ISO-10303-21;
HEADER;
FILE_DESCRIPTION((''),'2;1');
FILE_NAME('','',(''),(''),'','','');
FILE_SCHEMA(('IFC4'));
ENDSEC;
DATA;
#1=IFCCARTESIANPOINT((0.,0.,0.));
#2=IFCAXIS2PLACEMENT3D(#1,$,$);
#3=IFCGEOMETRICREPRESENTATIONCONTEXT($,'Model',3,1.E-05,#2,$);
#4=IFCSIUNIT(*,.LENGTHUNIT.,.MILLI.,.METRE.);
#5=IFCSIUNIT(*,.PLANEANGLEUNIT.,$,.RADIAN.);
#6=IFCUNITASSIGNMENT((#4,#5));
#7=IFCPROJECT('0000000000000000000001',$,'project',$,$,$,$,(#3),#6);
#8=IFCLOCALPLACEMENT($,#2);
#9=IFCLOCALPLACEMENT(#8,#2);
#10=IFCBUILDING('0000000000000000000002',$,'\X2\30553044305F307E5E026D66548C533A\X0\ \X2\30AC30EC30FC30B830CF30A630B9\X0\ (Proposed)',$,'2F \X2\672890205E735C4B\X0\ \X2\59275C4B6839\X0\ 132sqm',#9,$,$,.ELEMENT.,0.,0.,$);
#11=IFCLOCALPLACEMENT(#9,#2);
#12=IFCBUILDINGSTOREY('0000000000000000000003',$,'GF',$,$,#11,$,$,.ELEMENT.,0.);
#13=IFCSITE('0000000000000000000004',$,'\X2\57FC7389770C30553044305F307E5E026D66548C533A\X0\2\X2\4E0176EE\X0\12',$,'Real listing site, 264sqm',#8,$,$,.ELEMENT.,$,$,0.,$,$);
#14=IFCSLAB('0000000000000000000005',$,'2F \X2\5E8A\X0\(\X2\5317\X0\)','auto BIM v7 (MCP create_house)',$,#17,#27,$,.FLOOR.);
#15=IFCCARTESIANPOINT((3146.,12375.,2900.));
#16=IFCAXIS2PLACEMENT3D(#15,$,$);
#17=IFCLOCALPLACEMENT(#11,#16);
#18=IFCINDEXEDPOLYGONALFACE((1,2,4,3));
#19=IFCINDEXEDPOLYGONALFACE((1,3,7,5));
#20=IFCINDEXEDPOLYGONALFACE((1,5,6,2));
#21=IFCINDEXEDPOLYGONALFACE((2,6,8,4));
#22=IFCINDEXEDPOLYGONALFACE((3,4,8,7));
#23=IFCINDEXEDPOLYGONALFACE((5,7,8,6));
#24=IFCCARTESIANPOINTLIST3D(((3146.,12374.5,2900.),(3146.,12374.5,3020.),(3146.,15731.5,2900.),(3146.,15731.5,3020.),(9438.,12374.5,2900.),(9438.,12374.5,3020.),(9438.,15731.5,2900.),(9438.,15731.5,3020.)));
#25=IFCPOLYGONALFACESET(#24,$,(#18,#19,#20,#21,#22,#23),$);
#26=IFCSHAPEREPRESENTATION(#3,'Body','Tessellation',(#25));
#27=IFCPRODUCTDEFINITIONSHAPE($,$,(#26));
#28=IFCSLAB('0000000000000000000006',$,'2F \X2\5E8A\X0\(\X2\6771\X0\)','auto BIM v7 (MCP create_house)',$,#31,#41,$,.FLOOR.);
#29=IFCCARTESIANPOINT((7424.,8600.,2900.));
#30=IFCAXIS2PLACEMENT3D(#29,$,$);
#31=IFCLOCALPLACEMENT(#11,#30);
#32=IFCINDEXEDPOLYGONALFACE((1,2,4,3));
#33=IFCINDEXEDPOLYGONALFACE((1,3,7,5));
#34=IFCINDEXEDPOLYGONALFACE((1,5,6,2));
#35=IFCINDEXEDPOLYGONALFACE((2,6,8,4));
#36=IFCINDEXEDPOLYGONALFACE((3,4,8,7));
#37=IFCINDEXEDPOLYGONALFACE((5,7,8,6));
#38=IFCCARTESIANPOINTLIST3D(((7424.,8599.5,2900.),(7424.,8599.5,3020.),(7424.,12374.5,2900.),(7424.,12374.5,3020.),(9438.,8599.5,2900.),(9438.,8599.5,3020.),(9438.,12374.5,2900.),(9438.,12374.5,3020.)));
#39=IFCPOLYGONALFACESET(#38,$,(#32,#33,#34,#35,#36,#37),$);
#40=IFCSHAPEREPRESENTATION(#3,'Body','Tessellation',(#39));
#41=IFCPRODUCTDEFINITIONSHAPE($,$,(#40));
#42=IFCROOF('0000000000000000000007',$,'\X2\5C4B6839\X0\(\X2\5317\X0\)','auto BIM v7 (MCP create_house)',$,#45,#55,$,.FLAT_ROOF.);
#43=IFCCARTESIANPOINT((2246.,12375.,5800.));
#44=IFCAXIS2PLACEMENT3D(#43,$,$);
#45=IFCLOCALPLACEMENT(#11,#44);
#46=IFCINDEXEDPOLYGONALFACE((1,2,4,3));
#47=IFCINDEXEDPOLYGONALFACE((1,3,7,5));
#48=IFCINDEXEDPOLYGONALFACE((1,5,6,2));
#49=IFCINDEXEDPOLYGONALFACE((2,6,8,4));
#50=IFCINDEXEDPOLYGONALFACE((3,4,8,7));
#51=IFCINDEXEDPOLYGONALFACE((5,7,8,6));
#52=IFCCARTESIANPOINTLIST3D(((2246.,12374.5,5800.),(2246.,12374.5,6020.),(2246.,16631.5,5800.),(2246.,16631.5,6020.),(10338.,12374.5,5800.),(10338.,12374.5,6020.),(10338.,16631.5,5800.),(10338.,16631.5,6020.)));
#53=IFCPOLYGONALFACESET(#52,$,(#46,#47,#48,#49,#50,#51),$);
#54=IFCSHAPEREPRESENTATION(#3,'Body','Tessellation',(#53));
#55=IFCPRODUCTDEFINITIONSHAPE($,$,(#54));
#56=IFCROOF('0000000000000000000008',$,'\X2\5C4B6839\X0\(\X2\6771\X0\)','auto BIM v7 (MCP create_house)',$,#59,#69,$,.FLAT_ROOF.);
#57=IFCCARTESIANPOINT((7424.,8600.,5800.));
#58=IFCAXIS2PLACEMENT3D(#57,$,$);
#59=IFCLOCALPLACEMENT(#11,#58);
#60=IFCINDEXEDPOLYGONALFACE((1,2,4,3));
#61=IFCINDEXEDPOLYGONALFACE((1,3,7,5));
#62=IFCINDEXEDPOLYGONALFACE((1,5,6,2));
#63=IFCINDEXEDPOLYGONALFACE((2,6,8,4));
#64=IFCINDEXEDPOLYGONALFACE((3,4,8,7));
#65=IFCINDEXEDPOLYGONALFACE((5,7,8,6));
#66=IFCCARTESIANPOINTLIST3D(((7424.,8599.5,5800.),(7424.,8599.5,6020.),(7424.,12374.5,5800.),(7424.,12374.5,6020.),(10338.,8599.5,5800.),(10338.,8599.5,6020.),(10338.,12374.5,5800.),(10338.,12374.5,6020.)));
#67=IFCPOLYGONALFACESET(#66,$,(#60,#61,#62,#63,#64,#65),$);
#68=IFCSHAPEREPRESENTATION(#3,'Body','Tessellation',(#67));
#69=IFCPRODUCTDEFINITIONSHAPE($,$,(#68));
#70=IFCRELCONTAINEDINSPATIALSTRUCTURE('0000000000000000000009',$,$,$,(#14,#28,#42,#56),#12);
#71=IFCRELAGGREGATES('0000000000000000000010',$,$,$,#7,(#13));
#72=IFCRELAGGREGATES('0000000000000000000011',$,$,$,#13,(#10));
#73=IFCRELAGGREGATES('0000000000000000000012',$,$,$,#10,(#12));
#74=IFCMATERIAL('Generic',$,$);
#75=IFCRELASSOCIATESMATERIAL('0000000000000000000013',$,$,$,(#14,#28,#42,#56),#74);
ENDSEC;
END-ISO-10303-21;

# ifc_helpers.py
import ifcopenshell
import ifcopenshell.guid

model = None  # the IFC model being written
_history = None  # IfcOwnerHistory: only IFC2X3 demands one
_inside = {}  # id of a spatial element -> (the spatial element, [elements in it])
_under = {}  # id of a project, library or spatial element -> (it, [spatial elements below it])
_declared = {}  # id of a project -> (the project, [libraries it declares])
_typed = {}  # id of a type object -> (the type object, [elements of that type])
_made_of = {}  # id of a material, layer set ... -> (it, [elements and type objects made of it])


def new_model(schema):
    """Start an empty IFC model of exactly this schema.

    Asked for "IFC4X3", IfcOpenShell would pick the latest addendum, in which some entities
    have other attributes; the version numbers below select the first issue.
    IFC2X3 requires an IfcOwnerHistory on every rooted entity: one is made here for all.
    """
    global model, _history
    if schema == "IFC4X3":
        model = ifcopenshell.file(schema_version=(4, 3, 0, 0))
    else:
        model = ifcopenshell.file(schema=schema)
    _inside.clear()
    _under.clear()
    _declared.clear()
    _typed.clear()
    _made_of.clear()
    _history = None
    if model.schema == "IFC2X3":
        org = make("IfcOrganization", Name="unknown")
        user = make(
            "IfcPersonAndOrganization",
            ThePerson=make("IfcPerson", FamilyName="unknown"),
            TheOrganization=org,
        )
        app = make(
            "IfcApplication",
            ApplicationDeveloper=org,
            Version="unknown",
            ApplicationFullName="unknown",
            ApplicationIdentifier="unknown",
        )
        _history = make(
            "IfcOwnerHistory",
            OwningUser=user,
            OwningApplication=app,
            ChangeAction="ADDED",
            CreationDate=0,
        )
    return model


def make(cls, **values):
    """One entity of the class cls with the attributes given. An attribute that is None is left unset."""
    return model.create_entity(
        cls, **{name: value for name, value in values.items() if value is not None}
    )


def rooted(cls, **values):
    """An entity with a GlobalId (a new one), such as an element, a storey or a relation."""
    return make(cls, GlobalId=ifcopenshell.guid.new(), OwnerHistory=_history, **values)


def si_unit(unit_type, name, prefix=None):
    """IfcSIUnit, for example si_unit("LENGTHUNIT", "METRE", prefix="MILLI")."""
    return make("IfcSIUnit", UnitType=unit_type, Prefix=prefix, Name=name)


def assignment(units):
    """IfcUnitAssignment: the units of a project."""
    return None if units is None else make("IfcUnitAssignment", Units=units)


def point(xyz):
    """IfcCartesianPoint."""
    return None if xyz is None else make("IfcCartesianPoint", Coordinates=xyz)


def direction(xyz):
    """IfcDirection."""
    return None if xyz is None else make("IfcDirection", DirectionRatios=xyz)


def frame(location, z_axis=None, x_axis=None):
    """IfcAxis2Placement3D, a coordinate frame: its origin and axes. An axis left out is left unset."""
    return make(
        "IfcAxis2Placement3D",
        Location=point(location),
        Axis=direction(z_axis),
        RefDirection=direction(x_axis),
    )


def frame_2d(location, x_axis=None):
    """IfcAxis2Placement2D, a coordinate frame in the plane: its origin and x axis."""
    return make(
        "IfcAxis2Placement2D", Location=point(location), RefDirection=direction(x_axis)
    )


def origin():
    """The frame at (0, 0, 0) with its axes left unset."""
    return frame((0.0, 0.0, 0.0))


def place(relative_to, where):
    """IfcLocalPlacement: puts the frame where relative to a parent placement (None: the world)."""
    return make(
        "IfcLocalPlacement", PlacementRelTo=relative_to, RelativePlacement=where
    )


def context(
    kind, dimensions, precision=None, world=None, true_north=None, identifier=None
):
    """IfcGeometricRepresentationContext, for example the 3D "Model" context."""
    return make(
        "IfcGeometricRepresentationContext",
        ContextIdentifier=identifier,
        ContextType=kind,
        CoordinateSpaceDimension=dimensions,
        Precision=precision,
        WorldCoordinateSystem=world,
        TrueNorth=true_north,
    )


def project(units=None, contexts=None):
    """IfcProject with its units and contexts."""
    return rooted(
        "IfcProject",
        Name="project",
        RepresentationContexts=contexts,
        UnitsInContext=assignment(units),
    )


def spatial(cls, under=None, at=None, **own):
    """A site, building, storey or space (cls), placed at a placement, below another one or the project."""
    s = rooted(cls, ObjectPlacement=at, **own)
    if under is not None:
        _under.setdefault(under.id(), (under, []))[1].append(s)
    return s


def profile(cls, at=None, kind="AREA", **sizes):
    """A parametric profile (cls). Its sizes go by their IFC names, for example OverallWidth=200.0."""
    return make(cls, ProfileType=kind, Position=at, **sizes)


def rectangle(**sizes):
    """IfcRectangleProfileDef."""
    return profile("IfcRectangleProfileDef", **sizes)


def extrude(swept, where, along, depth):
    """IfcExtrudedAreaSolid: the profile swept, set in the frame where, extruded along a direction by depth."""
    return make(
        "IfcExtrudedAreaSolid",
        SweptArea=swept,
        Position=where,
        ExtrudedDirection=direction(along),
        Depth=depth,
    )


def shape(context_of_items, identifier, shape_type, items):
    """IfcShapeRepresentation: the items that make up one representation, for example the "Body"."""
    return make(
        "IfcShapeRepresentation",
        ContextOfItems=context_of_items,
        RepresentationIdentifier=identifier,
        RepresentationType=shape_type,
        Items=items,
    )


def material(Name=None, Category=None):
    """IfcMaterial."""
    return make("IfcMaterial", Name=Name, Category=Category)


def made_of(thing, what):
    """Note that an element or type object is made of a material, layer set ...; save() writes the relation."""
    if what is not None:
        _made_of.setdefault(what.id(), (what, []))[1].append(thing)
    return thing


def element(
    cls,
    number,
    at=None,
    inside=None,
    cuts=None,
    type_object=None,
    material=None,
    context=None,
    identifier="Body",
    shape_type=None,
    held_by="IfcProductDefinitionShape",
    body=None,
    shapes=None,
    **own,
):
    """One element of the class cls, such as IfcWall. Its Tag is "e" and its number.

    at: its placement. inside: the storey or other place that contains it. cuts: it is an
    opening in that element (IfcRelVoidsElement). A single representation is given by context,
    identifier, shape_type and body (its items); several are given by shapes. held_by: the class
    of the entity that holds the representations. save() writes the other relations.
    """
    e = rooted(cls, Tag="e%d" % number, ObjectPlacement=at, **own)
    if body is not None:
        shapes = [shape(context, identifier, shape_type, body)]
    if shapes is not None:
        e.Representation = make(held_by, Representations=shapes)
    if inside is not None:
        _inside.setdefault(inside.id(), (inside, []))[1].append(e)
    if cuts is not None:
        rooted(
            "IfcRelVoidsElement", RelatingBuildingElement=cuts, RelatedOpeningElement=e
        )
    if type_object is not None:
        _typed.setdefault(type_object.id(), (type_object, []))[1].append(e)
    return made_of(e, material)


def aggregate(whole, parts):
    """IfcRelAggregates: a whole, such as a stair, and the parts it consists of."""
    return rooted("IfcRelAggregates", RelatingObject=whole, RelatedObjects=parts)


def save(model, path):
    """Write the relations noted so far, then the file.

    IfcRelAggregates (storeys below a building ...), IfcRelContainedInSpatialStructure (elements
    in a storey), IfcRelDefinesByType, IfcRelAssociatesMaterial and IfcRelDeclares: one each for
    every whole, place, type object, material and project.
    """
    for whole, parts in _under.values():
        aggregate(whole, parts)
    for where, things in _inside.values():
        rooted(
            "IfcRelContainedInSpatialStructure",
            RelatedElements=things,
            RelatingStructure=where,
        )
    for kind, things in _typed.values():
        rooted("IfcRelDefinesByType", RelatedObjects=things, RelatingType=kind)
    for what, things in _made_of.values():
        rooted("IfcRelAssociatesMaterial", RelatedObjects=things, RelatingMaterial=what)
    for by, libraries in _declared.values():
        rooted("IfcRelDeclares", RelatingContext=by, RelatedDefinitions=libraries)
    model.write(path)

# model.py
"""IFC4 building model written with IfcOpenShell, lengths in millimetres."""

from ifc_helpers import new_model, si_unit, frame, frame_2d, origin, place, context, project, spatial, rectangle, extrude, material, element, save


model = new_model("IFC4")

# Units and contexts
model_context = context("Model", 3, precision=1e-05, world=origin())
ifc_project = project(units=[si_unit("LENGTHUNIT", "METRE", prefix="MILLI"), si_unit("PLANEANGLEUNIT", "RADIAN")], contexts=[model_context])

# Site, building, storey
site_placement = place(None, origin())
site = spatial("IfcSite", under=ifc_project, at=site_placement, Name="埼玉県さいたま市浦和区2丁目12", ObjectType="Real listing site, 264sqm", CompositionType="ELEMENT", RefElevation=0.0)
building_placement = place(site_placement, origin())
building = spatial("IfcBuilding", under=site, at=building_placement, Name="さいたま市浦和区 ガレージハウス (Proposed)", ObjectType="2F 木造平屋 大屋根 132sqm", CompositionType="ELEMENT", ElevationOfRefHeight=0.0, ElevationOfTerrain=0.0)
storey_placement = place(building_placement, origin())
storey = spatial("IfcBuildingStorey", under=building, at=storey_placement, Name="GF", CompositionType="ELEMENT", Elevation=0.0)

# Slabs
ifc_material = material(Name="Generic")
slab_1_placement = place(storey_placement, frame((3146.0, 12375.0, 2900.0)))
element("IfcSlab", 1, at=slab_1_placement, inside=storey, material=ifc_material, Name="2F 床(北)", Description="auto BIM v7 (MCP create_house)", PredefinedType="FLOOR", context=model_context, shape_type="SweptSolid", body=[
    extrude(rectangle(XDim=6292.0, YDim=3357.0, at=frame_2d((3146.0, 1678.0))), frame((3146.0, 12375.0, 2900.0)), (0.0, 0.0, 1.0), 120.0),
])
slab_2_placement = place(storey_placement, frame((7424.0, 8600.0, 2900.0)))
element("IfcSlab", 2, at=slab_2_placement, inside=storey, material=ifc_material, Name="2F 床(東)", Description="auto BIM v7 (MCP create_house)", PredefinedType="FLOOR", context=model_context, shape_type="SweptSolid", body=[
    extrude(rectangle(XDim=2014.0, YDim=3775.0, at=frame_2d((1007.0, 1887.0))), frame((7424.0, 8600.0, 2900.0)), (0.0, 0.0, 1.0), 120.0),
])

# Roofs
roof_1_placement = place(storey_placement, frame((2246.0, 12375.0, 5800.0)))
element("IfcRoof", 3, at=roof_1_placement, inside=storey, material=ifc_material, Name="屋根(北)", Description="auto BIM v7 (MCP create_house)", PredefinedType="FLAT_ROOF", context=model_context, shape_type="SweptSolid", body=[
    extrude(rectangle(XDim=8092.0, YDim=4257.0, at=frame_2d((4046.0, 2128.0))), frame((2246.0, 12375.0, 5800.0)), (0.0, 0.0, 1.0), 220.0),
])
roof_2_placement = place(storey_placement, frame((7424.0, 8600.0, 5800.0)))
element("IfcRoof", 4, at=roof_2_placement, inside=storey, material=ifc_material, Name="屋根(東)", Description="auto BIM v7 (MCP create_house)", PredefinedType="FLAT_ROOF", context=model_context, shape_type="SweptSolid", body=[
    extrude(rectangle(XDim=2914.0, YDim=3775.0, at=frame_2d((1457.0, 1887.0))), frame((7424.0, 8600.0, 5800.0)), (0.0, 0.0, 1.0), 220.0),
])

save(model, "model.ifc")
